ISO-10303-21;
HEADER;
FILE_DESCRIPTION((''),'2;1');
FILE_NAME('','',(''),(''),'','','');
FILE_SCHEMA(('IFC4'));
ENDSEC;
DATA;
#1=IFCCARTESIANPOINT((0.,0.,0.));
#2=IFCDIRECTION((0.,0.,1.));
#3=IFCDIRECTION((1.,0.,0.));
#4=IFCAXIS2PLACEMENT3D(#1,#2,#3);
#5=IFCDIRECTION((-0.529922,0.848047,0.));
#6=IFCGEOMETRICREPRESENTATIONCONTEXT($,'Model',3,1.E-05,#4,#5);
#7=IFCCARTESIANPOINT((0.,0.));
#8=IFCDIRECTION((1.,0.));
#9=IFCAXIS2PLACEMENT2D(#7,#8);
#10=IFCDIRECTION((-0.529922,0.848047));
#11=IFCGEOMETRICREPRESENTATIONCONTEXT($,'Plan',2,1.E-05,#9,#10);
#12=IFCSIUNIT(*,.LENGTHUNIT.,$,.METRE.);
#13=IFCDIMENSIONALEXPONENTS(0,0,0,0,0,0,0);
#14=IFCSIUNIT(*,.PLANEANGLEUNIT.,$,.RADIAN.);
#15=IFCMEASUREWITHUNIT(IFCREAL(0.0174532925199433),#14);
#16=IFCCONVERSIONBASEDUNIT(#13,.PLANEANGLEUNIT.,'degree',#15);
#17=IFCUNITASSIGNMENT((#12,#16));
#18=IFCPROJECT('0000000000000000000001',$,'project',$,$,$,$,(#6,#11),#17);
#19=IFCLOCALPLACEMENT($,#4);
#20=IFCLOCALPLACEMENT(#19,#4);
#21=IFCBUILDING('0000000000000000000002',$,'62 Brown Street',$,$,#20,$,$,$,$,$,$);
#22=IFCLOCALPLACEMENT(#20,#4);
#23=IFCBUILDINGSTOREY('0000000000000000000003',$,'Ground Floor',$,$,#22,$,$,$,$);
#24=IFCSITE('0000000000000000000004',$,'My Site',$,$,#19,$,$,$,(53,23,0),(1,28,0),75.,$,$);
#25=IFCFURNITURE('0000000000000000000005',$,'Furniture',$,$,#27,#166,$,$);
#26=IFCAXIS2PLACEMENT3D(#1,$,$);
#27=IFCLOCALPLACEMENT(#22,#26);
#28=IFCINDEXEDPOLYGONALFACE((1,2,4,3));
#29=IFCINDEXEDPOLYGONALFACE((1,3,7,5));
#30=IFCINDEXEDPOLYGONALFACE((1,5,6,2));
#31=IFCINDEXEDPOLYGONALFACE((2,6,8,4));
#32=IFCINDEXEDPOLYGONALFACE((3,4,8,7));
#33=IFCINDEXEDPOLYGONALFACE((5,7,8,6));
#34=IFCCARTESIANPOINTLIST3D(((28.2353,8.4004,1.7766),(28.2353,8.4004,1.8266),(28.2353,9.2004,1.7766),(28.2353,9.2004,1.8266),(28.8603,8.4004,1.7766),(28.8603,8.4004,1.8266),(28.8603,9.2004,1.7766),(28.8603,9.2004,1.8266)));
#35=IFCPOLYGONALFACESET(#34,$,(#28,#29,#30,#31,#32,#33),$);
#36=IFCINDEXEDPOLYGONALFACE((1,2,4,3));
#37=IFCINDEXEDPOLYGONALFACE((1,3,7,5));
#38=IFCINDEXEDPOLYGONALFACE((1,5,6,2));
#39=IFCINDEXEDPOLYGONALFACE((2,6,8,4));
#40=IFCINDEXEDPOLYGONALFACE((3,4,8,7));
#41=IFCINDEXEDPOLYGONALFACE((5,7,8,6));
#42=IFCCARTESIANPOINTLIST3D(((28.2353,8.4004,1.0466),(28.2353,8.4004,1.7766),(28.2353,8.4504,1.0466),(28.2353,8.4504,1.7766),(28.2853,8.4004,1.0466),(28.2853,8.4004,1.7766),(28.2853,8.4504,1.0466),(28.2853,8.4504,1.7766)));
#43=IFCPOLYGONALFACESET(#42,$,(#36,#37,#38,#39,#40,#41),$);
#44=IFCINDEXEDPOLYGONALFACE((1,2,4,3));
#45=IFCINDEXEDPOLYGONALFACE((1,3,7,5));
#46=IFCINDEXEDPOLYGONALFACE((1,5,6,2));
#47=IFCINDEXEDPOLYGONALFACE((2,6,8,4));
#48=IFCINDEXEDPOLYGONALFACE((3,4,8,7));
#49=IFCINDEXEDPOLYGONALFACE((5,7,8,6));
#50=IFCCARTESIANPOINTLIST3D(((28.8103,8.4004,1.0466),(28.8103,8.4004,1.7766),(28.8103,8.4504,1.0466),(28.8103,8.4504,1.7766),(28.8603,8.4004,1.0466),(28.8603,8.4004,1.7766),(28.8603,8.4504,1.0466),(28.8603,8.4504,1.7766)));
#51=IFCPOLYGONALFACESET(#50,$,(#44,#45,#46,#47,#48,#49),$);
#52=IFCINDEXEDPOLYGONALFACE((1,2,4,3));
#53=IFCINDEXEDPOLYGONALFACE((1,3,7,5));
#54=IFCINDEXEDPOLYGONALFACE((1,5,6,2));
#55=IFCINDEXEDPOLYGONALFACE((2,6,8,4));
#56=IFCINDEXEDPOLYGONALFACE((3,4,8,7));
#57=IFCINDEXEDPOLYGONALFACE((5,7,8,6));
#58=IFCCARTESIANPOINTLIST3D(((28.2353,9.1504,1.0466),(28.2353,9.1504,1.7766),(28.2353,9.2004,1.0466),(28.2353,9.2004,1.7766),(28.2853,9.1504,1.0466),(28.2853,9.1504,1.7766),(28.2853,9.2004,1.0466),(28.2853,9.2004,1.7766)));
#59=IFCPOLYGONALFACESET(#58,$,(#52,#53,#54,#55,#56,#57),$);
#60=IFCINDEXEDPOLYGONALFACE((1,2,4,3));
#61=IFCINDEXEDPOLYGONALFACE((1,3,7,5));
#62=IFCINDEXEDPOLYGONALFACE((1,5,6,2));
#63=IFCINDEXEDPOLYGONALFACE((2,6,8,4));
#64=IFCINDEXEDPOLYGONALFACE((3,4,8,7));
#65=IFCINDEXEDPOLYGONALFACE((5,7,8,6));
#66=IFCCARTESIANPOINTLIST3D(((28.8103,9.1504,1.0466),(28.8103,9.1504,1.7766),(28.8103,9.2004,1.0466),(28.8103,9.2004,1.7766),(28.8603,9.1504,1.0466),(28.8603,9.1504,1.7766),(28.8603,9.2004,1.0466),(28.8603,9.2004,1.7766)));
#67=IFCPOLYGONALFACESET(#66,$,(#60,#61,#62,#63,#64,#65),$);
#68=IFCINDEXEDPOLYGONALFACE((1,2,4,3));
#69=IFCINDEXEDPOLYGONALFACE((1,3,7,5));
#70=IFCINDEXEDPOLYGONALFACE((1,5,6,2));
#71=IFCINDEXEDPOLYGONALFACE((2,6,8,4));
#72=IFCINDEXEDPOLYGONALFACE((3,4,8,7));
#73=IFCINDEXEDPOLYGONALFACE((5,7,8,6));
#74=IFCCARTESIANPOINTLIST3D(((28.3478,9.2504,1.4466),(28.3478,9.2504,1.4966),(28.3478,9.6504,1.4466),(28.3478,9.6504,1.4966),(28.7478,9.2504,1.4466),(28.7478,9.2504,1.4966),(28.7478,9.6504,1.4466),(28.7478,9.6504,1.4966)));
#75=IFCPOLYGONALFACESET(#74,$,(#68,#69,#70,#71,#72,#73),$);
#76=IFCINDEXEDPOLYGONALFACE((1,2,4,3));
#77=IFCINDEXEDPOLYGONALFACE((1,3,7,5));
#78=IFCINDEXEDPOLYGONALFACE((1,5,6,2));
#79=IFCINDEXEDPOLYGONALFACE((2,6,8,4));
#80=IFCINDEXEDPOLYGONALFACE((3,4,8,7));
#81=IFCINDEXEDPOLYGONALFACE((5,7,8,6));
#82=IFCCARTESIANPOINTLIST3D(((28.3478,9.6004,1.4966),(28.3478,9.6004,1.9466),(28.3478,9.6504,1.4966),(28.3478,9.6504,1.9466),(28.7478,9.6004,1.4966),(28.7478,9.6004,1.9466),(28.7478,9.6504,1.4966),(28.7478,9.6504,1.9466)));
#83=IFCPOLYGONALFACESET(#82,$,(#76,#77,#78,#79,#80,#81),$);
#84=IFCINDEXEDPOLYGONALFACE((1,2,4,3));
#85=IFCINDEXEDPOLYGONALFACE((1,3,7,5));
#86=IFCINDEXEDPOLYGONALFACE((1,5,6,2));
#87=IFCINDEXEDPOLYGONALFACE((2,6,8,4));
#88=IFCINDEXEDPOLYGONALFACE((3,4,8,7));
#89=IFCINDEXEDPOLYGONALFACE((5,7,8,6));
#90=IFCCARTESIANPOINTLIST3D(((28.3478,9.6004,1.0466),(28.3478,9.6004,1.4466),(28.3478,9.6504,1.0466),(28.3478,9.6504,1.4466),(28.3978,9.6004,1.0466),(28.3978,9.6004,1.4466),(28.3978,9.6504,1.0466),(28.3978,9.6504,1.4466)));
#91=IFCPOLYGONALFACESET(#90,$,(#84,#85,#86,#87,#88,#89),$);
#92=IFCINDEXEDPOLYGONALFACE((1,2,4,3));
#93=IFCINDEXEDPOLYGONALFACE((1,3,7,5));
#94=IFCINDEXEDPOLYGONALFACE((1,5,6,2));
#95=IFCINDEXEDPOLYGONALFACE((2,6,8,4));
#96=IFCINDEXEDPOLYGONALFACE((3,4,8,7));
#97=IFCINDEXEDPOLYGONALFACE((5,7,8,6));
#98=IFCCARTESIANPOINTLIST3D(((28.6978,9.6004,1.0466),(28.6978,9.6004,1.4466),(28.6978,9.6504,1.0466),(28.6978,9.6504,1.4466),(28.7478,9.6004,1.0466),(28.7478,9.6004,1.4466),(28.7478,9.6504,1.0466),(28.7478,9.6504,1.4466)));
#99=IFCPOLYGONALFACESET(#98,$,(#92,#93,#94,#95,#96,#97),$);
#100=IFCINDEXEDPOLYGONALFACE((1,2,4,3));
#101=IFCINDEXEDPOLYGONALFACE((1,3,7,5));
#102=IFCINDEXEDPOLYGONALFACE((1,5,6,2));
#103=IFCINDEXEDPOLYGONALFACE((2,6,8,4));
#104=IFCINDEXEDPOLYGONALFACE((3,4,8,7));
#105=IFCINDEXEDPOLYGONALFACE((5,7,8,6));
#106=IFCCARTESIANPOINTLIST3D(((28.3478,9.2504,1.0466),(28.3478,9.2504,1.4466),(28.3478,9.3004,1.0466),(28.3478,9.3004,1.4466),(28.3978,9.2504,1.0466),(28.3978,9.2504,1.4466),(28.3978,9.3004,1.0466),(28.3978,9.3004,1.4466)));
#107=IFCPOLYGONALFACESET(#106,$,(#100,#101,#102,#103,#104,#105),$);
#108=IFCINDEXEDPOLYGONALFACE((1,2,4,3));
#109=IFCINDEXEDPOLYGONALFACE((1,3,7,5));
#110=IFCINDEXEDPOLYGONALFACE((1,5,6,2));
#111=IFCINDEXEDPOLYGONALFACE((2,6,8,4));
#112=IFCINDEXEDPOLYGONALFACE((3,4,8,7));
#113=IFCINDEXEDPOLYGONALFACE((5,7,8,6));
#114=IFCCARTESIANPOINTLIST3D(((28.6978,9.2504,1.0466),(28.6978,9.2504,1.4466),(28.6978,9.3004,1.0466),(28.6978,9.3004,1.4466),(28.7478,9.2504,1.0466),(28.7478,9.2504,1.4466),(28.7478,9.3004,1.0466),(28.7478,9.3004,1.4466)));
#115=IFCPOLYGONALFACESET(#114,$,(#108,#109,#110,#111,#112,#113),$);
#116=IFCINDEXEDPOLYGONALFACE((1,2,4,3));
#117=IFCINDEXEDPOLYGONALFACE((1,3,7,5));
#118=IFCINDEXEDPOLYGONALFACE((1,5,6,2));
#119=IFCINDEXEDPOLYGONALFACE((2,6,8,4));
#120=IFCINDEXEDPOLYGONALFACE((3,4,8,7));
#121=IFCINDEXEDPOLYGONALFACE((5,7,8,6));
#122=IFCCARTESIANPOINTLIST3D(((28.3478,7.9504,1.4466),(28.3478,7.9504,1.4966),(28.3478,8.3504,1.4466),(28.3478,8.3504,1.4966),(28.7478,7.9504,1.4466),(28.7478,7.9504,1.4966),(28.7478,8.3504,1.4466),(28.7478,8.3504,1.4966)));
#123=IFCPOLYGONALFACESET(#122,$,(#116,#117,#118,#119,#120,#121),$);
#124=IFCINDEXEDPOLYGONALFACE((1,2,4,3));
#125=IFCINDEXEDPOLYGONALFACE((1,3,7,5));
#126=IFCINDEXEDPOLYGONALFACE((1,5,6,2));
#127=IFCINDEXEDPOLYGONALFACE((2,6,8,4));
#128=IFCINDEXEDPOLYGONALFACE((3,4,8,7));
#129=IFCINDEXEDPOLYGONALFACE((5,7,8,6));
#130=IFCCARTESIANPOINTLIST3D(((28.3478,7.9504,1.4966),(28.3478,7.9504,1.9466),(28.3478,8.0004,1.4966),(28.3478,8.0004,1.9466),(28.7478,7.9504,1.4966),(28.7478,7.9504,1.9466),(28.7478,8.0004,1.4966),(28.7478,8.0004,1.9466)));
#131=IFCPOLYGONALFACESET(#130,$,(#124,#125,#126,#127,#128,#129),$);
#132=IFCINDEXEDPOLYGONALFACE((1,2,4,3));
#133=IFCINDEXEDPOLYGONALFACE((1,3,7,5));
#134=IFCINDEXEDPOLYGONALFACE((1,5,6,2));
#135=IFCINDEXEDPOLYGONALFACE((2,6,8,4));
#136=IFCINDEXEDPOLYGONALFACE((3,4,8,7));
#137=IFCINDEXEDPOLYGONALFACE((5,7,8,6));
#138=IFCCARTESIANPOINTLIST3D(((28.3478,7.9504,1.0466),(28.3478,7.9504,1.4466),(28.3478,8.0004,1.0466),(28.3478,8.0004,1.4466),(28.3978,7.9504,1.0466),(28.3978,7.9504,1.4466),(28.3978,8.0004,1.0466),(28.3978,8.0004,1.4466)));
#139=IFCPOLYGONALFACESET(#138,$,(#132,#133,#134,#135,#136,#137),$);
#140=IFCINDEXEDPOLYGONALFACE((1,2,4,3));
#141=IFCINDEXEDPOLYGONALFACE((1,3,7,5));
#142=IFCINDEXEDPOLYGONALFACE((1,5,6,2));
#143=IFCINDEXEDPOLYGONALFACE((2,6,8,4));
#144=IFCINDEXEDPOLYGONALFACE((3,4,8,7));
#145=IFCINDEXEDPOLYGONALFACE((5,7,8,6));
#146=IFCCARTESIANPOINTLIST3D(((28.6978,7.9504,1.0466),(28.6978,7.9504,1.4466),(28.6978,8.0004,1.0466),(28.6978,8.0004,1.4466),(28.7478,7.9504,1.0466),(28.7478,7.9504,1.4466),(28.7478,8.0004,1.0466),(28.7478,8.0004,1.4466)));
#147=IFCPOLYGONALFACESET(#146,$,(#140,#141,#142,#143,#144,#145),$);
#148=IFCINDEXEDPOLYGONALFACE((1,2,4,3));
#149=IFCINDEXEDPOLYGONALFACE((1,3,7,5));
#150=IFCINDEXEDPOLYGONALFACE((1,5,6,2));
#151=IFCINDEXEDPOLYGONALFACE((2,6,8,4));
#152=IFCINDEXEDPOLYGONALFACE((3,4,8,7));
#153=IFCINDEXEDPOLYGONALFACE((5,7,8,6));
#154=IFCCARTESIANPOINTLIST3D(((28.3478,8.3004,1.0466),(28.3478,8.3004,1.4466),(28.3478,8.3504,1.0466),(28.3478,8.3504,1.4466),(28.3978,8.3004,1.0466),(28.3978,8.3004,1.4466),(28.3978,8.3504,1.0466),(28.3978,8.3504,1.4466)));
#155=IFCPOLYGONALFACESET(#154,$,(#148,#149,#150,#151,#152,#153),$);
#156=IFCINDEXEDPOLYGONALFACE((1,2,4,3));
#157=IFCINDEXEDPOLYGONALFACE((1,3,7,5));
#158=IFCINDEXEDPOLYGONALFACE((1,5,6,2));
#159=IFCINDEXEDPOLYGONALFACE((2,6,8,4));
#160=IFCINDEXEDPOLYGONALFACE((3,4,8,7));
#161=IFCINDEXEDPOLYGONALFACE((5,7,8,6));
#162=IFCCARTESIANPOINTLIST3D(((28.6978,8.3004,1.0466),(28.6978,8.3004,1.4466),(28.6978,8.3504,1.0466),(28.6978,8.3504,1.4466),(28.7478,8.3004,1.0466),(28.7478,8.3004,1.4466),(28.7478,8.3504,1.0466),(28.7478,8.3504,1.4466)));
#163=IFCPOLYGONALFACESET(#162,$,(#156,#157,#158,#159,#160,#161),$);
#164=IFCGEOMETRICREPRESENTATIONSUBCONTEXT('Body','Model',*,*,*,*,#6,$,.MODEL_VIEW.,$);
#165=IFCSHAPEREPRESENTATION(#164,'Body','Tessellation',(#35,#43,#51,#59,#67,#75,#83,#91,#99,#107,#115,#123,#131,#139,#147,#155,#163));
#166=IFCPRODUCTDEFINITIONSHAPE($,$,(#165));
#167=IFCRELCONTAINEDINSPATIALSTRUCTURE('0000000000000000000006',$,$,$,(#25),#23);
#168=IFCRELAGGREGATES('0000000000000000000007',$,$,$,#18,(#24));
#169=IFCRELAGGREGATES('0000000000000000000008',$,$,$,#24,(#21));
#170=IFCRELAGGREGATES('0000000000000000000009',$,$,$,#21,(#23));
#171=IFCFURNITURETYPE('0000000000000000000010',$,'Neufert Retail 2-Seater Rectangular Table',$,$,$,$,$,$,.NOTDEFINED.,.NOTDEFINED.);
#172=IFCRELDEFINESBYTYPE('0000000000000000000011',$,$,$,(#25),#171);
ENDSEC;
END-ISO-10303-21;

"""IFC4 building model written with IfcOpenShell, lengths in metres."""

from ifc_helpers import new_model, entity, si_unit, converted_unit, direction, frame, origin_with_axes, origin_2d_with_axis, place, context, subcontext, project, spatial, line, indexed_curve, outline, extrude, shape, source, transform, mapped, type_object, type_shapes, element, save


model = new_model("IFC4")

# Units and contexts
model_context = context("Model", 3, precision=1e-05, world=origin_with_axes(), true_north=direction((-0.529922, 0.848047, 0.0)))
plan_context = context("Plan", 2, precision=1e-05, world=origin_2d_with_axis(), true_north=direction((-0.529922, 0.848047)))
body_context_1 = subcontext(model_context, "Body", "Model", "MODEL_VIEW")
body_context_2 = subcontext(plan_context, "Body", "Plan", "PLAN_VIEW")
ifc_project = project(units=[si_unit("LENGTHUNIT", "METRE"), converted_unit("PLANEANGLEUNIT", "degree", entity("IfcReal", 0.0174532925199433), si_unit("PLANEANGLEUNIT", "RADIAN"), dimensions=[0, 0, 0, 0, 0, 0, 0])], contexts=[model_context, plan_context])

# Site, building, storey
site_placement = place(None, origin_with_axes())
site = spatial("IfcSite", under=ifc_project, at=site_placement, Name="My Site", RefLatitude=(53, 23, 0), RefLongitude=(1, 28, 0), RefElevation=75.0)
building_placement = place(site_placement, origin_with_axes())
building = spatial("IfcBuilding", under=site, at=building_placement, Name="62 Brown Street")
storey_placement = place(building_placement, origin_with_axes())
storey = spatial("IfcBuildingStorey", under=building, at=storey_placement, Name="Ground Floor")

# Furniture
furniture_type_1 = type_object("IfcFurnitureType", Name="Neufert Retail 2-Seater Rectangular Table", AssemblyPlace="NOTDEFINED", PredefinedType="NOTDEFINED")
shared_shape_1 = source(origin_with_axes(), body_context_1, "Body", "SweptSolid", [
    extrude(outline(indexed_curve([(0.0, 0.0), (0.625, 0.0), (0.625, 0.8), (0.0, 0.8)], segments=[line(1, 2, 3, 4, 1)])), frame((-0.3125, -0.4, 0.73), z_axis=(0.0, 0.0, 1.0), x_axis=(1.0, 0.0, 0.0)), (0.0, 0.0, 1.0), 0.05),
    extrude(outline(indexed_curve([(0.0, 0.0), (0.05, 0.0), (0.05, 0.05), (0.0, 0.05)], segments=[line(1, 2, 3, 4, 1)])), frame((-0.3125, -0.4, 0.0), z_axis=(0.0, 0.0, 1.0), x_axis=(1.0, 0.0, 0.0)), (0.0, 0.0, 1.0), 0.73),
    extrude(outline(indexed_curve([(0.625, 0.0), (0.575, 0.0), (0.575, 0.05), (0.625, 0.05)], segments=[line(1, 2, 3, 4, 1)])), frame((-0.3125, -0.4, 0.0), z_axis=(0.0, 0.0, 1.0), x_axis=(1.0, 0.0, 0.0)), (0.0, 0.0, 1.0), 0.73),
    extrude(outline(indexed_curve([(0.0, 0.8), (0.05, 0.8), (0.05, 0.75), (0.0, 0.75)], segments=[line(1, 2, 3, 4, 1)])), frame((-0.3125, -0.4, 0.0), z_axis=(0.0, 0.0, 1.0), x_axis=(1.0, 0.0, 0.0)), (0.0, 0.0, 1.0), 0.73),
    extrude(outline(indexed_curve([(0.625, 0.8), (0.575, 0.8), (0.575, 0.75), (0.625, 0.75)], segments=[line(1, 2, 3, 4, 1)])), frame((-0.3125, -0.4, 0.0), z_axis=(0.0, 0.0, 1.0), x_axis=(1.0, 0.0, 0.0)), (0.0, 0.0, 1.0), 0.73),
    extrude(outline(indexed_curve([(-0.2, 0.0), (0.2, 0.0), (0.2, -0.4), (-0.2, -0.4)], segments=[line(1, 2, 3, 4, 1)])), frame((0.0, 0.85, 0.45), z_axis=(0.0, 0.0, 1.0), x_axis=(1.0, 0.0, 0.0)), (0.0, 0.0, -1.0), 0.05),
    extrude(outline(indexed_curve([(-0.2, 0.0), (0.2, 0.0), (0.2, -0.05), (-0.2, -0.05)], segments=[line(1, 2, 3, 4, 1)])), frame((0.0, 0.85, 0.9), z_axis=(0.0, 0.0, 1.0), x_axis=(1.0, 0.0, 0.0)), (0.0, 0.0, -1.0), 0.45),
    extrude(outline(indexed_curve([(-0.2, 0.0), (-0.15, 0.0), (-0.15, -0.05), (-0.2, -0.05)], segments=[line(1, 2, 3, 4, 1)])), frame((0.0, 0.85, 0.0), z_axis=(0.0, 0.0, 1.0), x_axis=(1.0, 0.0, 0.0)), (0.0, 0.0, 1.0), 0.4),
    extrude(outline(indexed_curve([(0.2, 0.0), (0.15, 0.0), (0.15, -0.05), (0.2, -0.05)], segments=[line(1, 2, 3, 4, 1)])), frame((0.0, 0.85, 0.0), z_axis=(0.0, 0.0, 1.0), x_axis=(1.0, 0.0, 0.0)), (0.0, 0.0, 1.0), 0.4),
    extrude(outline(indexed_curve([(-0.2, -0.4), (-0.15, -0.4), (-0.15, -0.35), (-0.2, -0.35)], segments=[line(1, 2, 3, 4, 1)])), frame((0.0, 0.85, 0.0), z_axis=(0.0, 0.0, 1.0), x_axis=(1.0, 0.0, 0.0)), (0.0, 0.0, 1.0), 0.4),
    extrude(outline(indexed_curve([(0.2, -0.4), (0.15, -0.4), (0.15, -0.35), (0.2, -0.35)], segments=[line(1, 2, 3, 4, 1)])), frame((0.0, 0.85, 0.0), z_axis=(0.0, 0.0, 1.0), x_axis=(1.0, 0.0, 0.0)), (0.0, 0.0, 1.0), 0.4),
    extrude(outline(indexed_curve([(-0.2, 0.0), (0.2, 0.0), (0.2, 0.4), (-0.2, 0.4)], segments=[line(1, 2, 3, 4, 1)])), frame((0.0, -0.85, 0.45), z_axis=(0.0, 0.0, 1.0), x_axis=(1.0, 0.0, 0.0)), (0.0, 0.0, -1.0), 0.05),
    extrude(outline(indexed_curve([(-0.2, 0.0), (0.2, 0.0), (0.2, 0.05), (-0.2, 0.05)], segments=[line(1, 2, 3, 4, 1)])), frame((0.0, -0.85, 0.9), z_axis=(0.0, 0.0, 1.0), x_axis=(1.0, 0.0, 0.0)), (0.0, 0.0, -1.0), 0.45),
    extrude(outline(indexed_curve([(-0.2, 0.0), (-0.15, 0.0), (-0.15, 0.05), (-0.2, 0.05)], segments=[line(1, 2, 3, 4, 1)])), frame((0.0, -0.85, 0.0), z_axis=(0.0, 0.0, 1.0), x_axis=(1.0, 0.0, 0.0)), (0.0, 0.0, 1.0), 0.4),
    extrude(outline(indexed_curve([(0.2, 0.0), (0.15, 0.0), (0.15, 0.05), (0.2, 0.05)], segments=[line(1, 2, 3, 4, 1)])), frame((0.0, -0.85, 0.0), z_axis=(0.0, 0.0, 1.0), x_axis=(1.0, 0.0, 0.0)), (0.0, 0.0, 1.0), 0.4),
    extrude(outline(indexed_curve([(-0.2, 0.4), (-0.15, 0.4), (-0.15, 0.35), (-0.2, 0.35)], segments=[line(1, 2, 3, 4, 1)])), frame((0.0, -0.85, 0.0), z_axis=(0.0, 0.0, 1.0), x_axis=(1.0, 0.0, 0.0)), (0.0, 0.0, 1.0), 0.4),
    extrude(outline(indexed_curve([(0.2, 0.4), (0.15, 0.4), (0.15, 0.35), (0.2, 0.35)], segments=[line(1, 2, 3, 4, 1)])), frame((0.0, -0.85, 0.0), z_axis=(0.0, 0.0, 1.0), x_axis=(1.0, 0.0, 0.0)), (0.0, 0.0, 1.0), 0.4),
])
shared_shape_2 = source(origin_with_axes(), body_context_2, "Body", "Curve2D", [
    entity("IfcIndexedPolyCurve", entity("IfcCartesianPointList2D", [[-0.3125, -0.4], [0.3125, -0.4], [0.3125, 0.4], [-0.3125, 0.4]]), [entity("IfcLineIndex", [1, 2, 3, 4, 1])]),
    entity("IfcIndexedPolyCurve", entity("IfcCartesianPointList2D", [[-0.2, 0.45], [0.2, 0.45]])),
    entity("IfcIndexedPolyCurve", entity("IfcCartesianPointList2D", [[-0.2, 0.45], [-0.2, 0.65], [-0.1414, 0.7914], [0.0, 0.85], [0.1414, 0.7914], [0.2, 0.65], [0.2, 0.45]]), [entity("IfcLineIndex", [1, 2]), entity("IfcArcIndex", [2, 3, 4]), entity("IfcArcIndex", [4, 5, 6]), entity("IfcLineIndex", [6, 7])]),
    entity("IfcIndexedPolyCurve", entity("IfcCartesianPointList2D", [[-0.16, 0.45], [-0.16, 0.65], [-0.1131, 0.7631], [0.0, 0.81], [0.1131, 0.7631], [0.16, 0.65], [0.16, 0.45]]), [entity("IfcLineIndex", [1, 2]), entity("IfcArcIndex", [2, 3, 4]), entity("IfcArcIndex", [4, 5, 6]), entity("IfcLineIndex", [6, 7])]),
    entity("IfcIndexedPolyCurve", entity("IfcCartesianPointList2D", [[-0.2, -0.45], [0.2, -0.45]])),
    entity("IfcIndexedPolyCurve", entity("IfcCartesianPointList2D", [[-0.2, -0.45], [-0.2, -0.65], [-0.1414, -0.7914], [0.0, -0.85], [0.1414, -0.7914], [0.2, -0.65], [0.2, -0.45]]), [entity("IfcLineIndex", [1, 2]), entity("IfcArcIndex", [2, 3, 4]), entity("IfcArcIndex", [4, 5, 6]), entity("IfcLineIndex", [6, 7])]),
    entity("IfcIndexedPolyCurve", entity("IfcCartesianPointList2D", [[-0.16, -0.45], [-0.16, -0.65], [-0.1131, -0.7631], [0.0, -0.81], [0.1131, -0.7631], [0.16, -0.65], [0.16, -0.45]]), [entity("IfcLineIndex", [1, 2]), entity("IfcArcIndex", [2, 3, 4]), entity("IfcArcIndex", [4, 5, 6]), entity("IfcLineIndex", [6, 7])]),
])
type_shapes(furniture_type_1, [shared_shape_1, shared_shape_2])
furniture_placement = place(storey_placement, frame((28.5478, 8.8004, 1.0466), z_axis=(0.0, 0.0, 1.0), x_axis=(1.0, 0.0, 0.0)))
element("IfcFurniture", 1, at=furniture_placement, inside=storey, type_object=furniture_type_1, Name="Furniture", shapes=[
    shape(body_context_1, "Body", "MappedRepresentation", [mapped(shared_shape_1, transform((0.0, 0.0, 0.0), x_axis=(1.0, 0.0, 0.0), y_axis=(0.0, 1.0, 0.0), z_axis=(0.0, 0.0, 1.0), scale=1.0))]),
    shape(body_context_2, "Body", "MappedRepresentation", [mapped(shared_shape_2, transform((0.0, 0.0, 0.0), x_axis=(1.0, 0.0, 0.0), y_axis=(0.0, 1.0, 0.0), z_axis=(0.0, 0.0, 1.0), scale=1.0))]),
])

save(model, "model.ifc")
